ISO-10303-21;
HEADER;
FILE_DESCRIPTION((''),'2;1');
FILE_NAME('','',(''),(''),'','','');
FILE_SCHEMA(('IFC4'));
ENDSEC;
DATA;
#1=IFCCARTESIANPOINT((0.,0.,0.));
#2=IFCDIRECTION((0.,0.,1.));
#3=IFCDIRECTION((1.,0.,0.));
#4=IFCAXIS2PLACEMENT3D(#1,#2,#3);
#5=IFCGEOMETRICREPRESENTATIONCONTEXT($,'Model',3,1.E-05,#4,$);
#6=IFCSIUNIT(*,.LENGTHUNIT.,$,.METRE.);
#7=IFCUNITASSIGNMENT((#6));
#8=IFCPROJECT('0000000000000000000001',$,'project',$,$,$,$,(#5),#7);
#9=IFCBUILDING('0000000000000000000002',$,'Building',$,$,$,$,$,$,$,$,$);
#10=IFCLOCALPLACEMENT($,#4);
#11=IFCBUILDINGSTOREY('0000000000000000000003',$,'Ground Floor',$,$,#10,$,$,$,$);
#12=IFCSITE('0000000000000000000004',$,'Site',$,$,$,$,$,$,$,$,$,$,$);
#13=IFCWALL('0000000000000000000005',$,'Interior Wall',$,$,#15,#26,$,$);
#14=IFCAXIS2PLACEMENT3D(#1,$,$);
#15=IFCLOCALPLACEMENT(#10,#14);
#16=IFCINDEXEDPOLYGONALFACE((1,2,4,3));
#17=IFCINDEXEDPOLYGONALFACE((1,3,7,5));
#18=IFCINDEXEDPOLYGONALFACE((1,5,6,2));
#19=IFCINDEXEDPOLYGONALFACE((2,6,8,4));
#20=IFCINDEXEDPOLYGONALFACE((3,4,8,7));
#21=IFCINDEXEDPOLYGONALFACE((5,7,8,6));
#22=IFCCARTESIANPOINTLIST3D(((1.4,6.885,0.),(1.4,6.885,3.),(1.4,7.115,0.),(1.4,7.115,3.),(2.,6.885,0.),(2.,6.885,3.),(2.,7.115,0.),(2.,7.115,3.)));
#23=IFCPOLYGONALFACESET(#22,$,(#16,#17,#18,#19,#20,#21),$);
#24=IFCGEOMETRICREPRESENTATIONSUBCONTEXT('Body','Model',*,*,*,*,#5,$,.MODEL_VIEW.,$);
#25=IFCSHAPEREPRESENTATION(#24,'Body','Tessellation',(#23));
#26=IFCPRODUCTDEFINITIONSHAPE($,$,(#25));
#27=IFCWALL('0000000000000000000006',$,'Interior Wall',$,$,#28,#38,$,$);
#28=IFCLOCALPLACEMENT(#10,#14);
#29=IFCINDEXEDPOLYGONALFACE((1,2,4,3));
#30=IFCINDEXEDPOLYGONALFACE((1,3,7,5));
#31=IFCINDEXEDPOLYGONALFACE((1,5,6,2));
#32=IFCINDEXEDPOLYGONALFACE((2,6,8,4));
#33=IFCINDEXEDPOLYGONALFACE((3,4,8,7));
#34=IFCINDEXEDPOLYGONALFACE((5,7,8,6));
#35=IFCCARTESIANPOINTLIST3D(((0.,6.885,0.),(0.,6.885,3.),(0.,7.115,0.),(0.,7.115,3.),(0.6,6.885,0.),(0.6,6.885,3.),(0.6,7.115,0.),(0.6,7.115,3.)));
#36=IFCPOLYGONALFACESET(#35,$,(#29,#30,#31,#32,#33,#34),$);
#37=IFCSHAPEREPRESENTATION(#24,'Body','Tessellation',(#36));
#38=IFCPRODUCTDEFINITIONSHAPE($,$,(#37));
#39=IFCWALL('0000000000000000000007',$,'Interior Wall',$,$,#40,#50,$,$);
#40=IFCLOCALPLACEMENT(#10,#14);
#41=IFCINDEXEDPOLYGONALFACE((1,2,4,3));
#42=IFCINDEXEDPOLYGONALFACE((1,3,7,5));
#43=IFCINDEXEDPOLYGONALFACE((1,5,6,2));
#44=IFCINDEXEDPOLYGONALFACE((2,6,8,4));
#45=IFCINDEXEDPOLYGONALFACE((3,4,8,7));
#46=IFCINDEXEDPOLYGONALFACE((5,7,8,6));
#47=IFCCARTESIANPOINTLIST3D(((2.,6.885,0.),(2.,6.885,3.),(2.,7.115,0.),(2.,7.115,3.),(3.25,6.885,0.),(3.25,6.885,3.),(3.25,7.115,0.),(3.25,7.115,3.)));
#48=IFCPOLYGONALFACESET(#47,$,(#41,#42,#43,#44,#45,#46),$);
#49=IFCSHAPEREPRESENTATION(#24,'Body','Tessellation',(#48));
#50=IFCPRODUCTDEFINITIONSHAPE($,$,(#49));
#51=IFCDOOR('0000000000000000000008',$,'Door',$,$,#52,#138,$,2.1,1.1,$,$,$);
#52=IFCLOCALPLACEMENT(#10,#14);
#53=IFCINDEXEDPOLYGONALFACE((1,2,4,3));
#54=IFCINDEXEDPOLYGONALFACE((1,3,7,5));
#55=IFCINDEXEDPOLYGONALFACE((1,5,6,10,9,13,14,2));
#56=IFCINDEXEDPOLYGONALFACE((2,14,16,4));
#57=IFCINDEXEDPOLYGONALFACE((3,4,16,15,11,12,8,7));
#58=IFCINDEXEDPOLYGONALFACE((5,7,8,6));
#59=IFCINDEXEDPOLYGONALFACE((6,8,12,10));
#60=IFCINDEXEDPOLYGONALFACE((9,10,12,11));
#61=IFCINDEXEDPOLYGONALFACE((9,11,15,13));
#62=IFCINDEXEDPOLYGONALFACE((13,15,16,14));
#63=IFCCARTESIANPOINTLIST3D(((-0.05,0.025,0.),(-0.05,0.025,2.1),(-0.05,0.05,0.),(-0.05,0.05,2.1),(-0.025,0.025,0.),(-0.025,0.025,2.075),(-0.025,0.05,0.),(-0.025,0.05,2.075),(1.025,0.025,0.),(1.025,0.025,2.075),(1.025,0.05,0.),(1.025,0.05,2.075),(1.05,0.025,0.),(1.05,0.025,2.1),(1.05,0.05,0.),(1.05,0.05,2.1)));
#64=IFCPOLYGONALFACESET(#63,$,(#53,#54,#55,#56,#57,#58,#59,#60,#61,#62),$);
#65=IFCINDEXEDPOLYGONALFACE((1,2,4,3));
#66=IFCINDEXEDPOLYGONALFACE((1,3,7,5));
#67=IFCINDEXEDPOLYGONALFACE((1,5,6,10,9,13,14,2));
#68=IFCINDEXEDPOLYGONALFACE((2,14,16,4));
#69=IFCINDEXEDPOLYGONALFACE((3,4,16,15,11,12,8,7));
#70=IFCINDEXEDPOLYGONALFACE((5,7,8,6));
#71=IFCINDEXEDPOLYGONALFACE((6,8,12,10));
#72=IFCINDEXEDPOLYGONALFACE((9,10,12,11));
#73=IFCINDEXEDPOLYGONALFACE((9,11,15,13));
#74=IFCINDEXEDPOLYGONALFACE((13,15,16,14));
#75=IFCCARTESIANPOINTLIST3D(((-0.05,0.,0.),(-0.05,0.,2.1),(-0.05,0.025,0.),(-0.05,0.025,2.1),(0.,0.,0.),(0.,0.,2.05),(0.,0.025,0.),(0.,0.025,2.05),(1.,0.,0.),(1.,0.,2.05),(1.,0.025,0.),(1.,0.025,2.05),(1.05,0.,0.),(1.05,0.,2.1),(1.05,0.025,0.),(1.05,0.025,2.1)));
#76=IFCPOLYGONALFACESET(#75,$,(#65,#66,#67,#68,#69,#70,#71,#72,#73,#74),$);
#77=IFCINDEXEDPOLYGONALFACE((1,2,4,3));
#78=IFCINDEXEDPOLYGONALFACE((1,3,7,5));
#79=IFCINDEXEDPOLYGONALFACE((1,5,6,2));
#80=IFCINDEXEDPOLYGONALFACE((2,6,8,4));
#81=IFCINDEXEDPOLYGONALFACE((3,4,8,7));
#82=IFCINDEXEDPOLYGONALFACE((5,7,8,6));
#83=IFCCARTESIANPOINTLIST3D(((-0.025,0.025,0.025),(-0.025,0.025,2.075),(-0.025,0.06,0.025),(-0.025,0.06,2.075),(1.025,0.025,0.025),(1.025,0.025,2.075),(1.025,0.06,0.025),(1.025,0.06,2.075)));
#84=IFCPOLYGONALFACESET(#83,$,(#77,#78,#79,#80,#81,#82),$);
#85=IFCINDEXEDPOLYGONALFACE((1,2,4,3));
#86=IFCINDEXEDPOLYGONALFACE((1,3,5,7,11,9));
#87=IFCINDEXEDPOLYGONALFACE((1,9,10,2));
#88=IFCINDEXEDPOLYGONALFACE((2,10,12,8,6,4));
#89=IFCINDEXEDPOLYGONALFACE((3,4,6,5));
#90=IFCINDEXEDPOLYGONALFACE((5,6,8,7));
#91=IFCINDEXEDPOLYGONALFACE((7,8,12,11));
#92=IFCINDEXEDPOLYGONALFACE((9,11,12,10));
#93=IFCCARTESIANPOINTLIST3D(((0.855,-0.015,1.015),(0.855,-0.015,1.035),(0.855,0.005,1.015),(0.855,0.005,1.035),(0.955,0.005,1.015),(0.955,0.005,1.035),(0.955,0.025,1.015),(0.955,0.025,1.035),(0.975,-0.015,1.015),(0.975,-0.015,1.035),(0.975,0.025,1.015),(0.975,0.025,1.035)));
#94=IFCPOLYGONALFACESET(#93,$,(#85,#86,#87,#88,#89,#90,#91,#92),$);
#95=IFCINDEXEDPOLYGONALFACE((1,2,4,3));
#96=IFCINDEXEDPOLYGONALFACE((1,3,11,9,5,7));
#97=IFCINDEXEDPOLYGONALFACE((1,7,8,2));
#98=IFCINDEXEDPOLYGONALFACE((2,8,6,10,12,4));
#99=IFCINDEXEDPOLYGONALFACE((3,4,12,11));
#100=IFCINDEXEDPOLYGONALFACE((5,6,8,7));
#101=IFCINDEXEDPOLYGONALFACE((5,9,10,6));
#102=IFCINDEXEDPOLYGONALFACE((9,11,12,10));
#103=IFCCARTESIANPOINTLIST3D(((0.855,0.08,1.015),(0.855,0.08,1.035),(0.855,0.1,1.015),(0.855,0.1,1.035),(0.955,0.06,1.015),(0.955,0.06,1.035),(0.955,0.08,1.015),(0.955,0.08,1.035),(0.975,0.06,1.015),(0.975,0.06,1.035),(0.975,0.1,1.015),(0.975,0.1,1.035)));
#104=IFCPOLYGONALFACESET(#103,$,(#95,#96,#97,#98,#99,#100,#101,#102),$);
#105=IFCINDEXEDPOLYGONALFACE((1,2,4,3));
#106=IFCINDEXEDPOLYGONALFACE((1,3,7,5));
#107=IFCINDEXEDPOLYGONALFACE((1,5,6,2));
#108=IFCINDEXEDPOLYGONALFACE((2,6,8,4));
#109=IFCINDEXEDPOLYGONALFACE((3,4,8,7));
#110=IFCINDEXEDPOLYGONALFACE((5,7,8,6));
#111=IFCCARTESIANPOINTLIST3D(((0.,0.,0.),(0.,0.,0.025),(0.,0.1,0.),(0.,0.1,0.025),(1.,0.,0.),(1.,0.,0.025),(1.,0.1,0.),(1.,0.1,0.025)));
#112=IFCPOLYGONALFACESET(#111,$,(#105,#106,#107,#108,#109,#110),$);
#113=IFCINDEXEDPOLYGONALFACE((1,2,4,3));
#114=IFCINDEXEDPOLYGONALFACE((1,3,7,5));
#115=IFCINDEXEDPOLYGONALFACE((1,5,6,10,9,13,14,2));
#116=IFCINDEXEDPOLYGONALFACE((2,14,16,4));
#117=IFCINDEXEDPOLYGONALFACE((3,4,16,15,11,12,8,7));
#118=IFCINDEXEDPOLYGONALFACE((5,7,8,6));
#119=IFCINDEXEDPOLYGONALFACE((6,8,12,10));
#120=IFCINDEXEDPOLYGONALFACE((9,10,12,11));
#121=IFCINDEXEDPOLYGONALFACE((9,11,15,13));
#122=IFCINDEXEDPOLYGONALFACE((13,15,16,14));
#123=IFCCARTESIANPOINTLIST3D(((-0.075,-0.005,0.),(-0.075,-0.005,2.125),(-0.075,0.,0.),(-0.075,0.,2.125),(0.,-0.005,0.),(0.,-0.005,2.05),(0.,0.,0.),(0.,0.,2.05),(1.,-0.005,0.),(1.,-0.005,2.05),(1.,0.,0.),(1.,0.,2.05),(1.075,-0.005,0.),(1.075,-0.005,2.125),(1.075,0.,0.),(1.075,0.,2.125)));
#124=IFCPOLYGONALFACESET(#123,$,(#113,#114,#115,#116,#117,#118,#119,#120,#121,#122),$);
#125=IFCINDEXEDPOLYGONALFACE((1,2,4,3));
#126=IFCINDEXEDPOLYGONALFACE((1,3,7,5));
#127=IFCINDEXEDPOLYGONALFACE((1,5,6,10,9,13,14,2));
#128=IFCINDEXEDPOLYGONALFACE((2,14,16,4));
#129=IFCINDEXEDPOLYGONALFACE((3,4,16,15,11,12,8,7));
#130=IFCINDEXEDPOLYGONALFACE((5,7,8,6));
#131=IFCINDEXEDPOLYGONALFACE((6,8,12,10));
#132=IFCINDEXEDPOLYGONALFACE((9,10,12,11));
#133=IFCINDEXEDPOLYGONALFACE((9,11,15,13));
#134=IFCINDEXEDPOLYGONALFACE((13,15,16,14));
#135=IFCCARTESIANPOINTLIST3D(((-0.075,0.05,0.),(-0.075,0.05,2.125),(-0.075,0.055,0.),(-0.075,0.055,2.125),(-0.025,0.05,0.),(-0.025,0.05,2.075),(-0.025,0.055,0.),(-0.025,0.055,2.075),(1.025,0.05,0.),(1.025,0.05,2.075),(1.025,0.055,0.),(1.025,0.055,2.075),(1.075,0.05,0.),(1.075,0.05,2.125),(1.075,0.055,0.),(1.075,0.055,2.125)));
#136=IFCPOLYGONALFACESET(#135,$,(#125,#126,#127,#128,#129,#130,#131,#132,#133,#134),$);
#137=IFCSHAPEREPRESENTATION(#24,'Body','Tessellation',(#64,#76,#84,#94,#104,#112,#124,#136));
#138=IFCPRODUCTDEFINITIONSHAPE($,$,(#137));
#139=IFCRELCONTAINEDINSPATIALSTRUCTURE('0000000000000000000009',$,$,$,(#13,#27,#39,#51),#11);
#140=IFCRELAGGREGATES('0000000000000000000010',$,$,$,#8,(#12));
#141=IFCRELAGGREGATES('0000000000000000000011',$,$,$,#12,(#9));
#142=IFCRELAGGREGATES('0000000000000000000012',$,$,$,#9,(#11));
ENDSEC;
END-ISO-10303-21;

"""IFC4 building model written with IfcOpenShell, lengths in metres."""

from ifc_helpers import new_model, si_unit, frame, origin_with_axes, place, context, subcontext, project, spatial, line, indexed_curve, outline, extrude, element, save


model = new_model("IFC4")

# Units and contexts
model_context = context("Model", 3, precision=1e-05, world=origin_with_axes())
body_context = subcontext(model_context, "Body", "Model", "MODEL_VIEW")
ifc_project = project(units=[si_unit("LENGTHUNIT", "METRE")], contexts=[model_context])

# Site, building, storey
site = spatial("IfcSite", under=ifc_project, Name="Site")
building = spatial("IfcBuilding", under=site, Name="Building")
storey_placement = place(None, origin_with_axes())
storey = spatial("IfcBuildingStorey", under=building, at=storey_placement, Name="Ground Floor")

# Walls
for number, where, z_axis, x_axis, name in (
    (1, (2.0, 7.0, 0.0), (0.0, 0.0, 1.0), (-1.0, 0.0, 0.0), "Interior Wall"),
    (2, (0.6, 7.0, 0.0), (0.0, 0.0, 1.0), (-1.0, 0.0, 0.0), "Interior Wall"),
):
    element("IfcWall", number, at=place(storey_placement, frame(where, z_axis=z_axis, x_axis=x_axis)), inside=storey, Name=name, context=body_context, shape_type="SweptSolid", body=[
        extrude(outline(indexed_curve([(0.0, 0.0), (0.0, 0.23), (0.6, 0.23), (0.6, 0.0), (0.0, 0.0)], self_intersect=False)), frame((0.0, -0.115, 0.0), z_axis=(0.0, 0.0, 1.0), x_axis=(1.0, 0.0, 0.0)), (0.0, 0.0, 1.0), 3.0),
    ])
wall_1_placement = place(storey_placement, frame((3.25, 7.0, 0.0), z_axis=(0.0, 0.0, 1.0), x_axis=(-1.0, 0.0, 0.0)))
element("IfcWall", 3, at=wall_1_placement, inside=storey, Name="Interior Wall", context=body_context, shape_type="SweptSolid", body=[
    extrude(outline(indexed_curve([(0.0, 0.0), (0.0, 0.23), (1.25, 0.23), (1.25, 0.0), (0.0, 0.0)], self_intersect=False)), frame((0.0, -0.115, 0.0), z_axis=(0.0, 0.0, 1.0), x_axis=(1.0, 0.0, 0.0)), (0.0, 0.0, 1.0), 3.0),
])

# Door
door_1_placement = place(storey_placement, frame((-0.05, 0.0, 0.0), z_axis=(0.0, 0.0, 1.0), x_axis=(1.0, 0.0, 0.0)))
element("IfcDoor", 4, at=door_1_placement, inside=storey, Name="Door", OverallHeight=2.1, OverallWidth=1.1, context=body_context, shape_type="SweptSolid", body=[
    extrude(outline(indexed_curve([(0.0, 0.0), (0.0, 2.1), (1.1, 2.1), (1.1, 0.0), (1.075, 0.0), (1.075, 2.075), (0.025, 2.075), (0.025, 0.0)], segments=[line(1, 2, 3, 4, 5, 6, 7, 8, 1)])), frame((0.0, 0.025, 0.0), z_axis=(0.0, -1.0, 0.0), x_axis=(1.0, 0.0, 0.0)), (0.0, 0.0, -1.0), 0.025),
    extrude(outline(indexed_curve([(0.0, 0.0), (0.0, 2.1), (1.1, 2.1), (1.1, 0.0), (1.05, 0.0), (1.05, 2.05), (0.05, 2.05), (0.05, 0.0)], segments=[line(1, 2, 3, 4, 5, 6, 7, 8, 1)])), frame((0.0, 0.0, 0.0), z_axis=(0.0, -1.0, 0.0), x_axis=(1.0, 0.0, 0.0)), (0.0, 0.0, -1.0), 0.025),
    extrude(outline(indexed_curve([(0.0, 0.0), (1.05, 0.0), (1.05, 0.035), (0.0, 0.035)], segments=[line(1, 2, 3, 4, 1)])), frame((0.025, 0.025, 0.025), z_axis=(0.0, 0.0, 1.0), x_axis=(1.0, 0.0, 0.0)), (0.0, 0.0, 1.0), 2.05),
    extrude(outline(indexed_curve([(0.0, 0.0), (0.0, -0.04), (-0.12, -0.04), (-0.12, -0.02), (-0.02, -0.02), (-0.02, 0.0)], segments=[line(1, 2, 3, 4, 5, 6, 1)])), frame((1.025, 0.025, 1.015), z_axis=(0.0, 0.0, 1.0), x_axis=(1.0, 0.0, 0.0)), (0.0, 0.0, 1.0), 0.02),
    extrude(outline(indexed_curve([(0.0, 0.0), (0.0, 0.04), (-0.12, 0.04), (-0.12, 0.02), (-0.02, 0.02), (-0.02, 0.0)], segments=[line(1, 2, 3, 4, 5, 6, 1)])), frame((1.025, 0.06, 1.015), z_axis=(0.0, 0.0, 1.0), x_axis=(1.0, 0.0, 0.0)), (0.0, 0.0, 1.0), 0.02),
    extrude(outline(indexed_curve([(0.0, 0.0), (1.0, 0.0), (1.0, 0.1), (0.0, 0.1)], segments=[line(1, 2, 3, 4, 1)])), frame((0.05, 0.0, 0.0), z_axis=(0.0, 0.0, 1.0), x_axis=(1.0, 0.0, 0.0)), (0.0, 0.0, 1.0), 0.025),
    extrude(outline(indexed_curve([(0.0, 0.0), (0.0, 2.125), (1.15, 2.125), (1.15, 0.0), (1.075, 0.0), (1.075, 2.05), (0.075, 2.05), (0.075, 0.0)], segments=[line(1, 2, 3, 4, 5, 6, 7, 8, 1)])), frame((-0.025, -0.005, 0.0), z_axis=(0.0, -1.0, 0.0), x_axis=(1.0, 0.0, 0.0)), (0.0, 0.0, -1.0), 0.005),
    extrude(outline(indexed_curve([(0.0, 0.0), (0.0, 2.125), (1.15, 2.125), (1.15, 0.0), (1.1, 0.0), (1.1, 2.075), (0.05, 2.075), (0.05, 0.0)], segments=[line(1, 2, 3, 4, 5, 6, 7, 8, 1)])), frame((-0.025, 0.05, 0.0), z_axis=(0.0, -1.0, 0.0), x_axis=(1.0, 0.0, 0.0)), (0.0, 0.0, -1.0), 0.005),
])

save(model, "model.ifc")
